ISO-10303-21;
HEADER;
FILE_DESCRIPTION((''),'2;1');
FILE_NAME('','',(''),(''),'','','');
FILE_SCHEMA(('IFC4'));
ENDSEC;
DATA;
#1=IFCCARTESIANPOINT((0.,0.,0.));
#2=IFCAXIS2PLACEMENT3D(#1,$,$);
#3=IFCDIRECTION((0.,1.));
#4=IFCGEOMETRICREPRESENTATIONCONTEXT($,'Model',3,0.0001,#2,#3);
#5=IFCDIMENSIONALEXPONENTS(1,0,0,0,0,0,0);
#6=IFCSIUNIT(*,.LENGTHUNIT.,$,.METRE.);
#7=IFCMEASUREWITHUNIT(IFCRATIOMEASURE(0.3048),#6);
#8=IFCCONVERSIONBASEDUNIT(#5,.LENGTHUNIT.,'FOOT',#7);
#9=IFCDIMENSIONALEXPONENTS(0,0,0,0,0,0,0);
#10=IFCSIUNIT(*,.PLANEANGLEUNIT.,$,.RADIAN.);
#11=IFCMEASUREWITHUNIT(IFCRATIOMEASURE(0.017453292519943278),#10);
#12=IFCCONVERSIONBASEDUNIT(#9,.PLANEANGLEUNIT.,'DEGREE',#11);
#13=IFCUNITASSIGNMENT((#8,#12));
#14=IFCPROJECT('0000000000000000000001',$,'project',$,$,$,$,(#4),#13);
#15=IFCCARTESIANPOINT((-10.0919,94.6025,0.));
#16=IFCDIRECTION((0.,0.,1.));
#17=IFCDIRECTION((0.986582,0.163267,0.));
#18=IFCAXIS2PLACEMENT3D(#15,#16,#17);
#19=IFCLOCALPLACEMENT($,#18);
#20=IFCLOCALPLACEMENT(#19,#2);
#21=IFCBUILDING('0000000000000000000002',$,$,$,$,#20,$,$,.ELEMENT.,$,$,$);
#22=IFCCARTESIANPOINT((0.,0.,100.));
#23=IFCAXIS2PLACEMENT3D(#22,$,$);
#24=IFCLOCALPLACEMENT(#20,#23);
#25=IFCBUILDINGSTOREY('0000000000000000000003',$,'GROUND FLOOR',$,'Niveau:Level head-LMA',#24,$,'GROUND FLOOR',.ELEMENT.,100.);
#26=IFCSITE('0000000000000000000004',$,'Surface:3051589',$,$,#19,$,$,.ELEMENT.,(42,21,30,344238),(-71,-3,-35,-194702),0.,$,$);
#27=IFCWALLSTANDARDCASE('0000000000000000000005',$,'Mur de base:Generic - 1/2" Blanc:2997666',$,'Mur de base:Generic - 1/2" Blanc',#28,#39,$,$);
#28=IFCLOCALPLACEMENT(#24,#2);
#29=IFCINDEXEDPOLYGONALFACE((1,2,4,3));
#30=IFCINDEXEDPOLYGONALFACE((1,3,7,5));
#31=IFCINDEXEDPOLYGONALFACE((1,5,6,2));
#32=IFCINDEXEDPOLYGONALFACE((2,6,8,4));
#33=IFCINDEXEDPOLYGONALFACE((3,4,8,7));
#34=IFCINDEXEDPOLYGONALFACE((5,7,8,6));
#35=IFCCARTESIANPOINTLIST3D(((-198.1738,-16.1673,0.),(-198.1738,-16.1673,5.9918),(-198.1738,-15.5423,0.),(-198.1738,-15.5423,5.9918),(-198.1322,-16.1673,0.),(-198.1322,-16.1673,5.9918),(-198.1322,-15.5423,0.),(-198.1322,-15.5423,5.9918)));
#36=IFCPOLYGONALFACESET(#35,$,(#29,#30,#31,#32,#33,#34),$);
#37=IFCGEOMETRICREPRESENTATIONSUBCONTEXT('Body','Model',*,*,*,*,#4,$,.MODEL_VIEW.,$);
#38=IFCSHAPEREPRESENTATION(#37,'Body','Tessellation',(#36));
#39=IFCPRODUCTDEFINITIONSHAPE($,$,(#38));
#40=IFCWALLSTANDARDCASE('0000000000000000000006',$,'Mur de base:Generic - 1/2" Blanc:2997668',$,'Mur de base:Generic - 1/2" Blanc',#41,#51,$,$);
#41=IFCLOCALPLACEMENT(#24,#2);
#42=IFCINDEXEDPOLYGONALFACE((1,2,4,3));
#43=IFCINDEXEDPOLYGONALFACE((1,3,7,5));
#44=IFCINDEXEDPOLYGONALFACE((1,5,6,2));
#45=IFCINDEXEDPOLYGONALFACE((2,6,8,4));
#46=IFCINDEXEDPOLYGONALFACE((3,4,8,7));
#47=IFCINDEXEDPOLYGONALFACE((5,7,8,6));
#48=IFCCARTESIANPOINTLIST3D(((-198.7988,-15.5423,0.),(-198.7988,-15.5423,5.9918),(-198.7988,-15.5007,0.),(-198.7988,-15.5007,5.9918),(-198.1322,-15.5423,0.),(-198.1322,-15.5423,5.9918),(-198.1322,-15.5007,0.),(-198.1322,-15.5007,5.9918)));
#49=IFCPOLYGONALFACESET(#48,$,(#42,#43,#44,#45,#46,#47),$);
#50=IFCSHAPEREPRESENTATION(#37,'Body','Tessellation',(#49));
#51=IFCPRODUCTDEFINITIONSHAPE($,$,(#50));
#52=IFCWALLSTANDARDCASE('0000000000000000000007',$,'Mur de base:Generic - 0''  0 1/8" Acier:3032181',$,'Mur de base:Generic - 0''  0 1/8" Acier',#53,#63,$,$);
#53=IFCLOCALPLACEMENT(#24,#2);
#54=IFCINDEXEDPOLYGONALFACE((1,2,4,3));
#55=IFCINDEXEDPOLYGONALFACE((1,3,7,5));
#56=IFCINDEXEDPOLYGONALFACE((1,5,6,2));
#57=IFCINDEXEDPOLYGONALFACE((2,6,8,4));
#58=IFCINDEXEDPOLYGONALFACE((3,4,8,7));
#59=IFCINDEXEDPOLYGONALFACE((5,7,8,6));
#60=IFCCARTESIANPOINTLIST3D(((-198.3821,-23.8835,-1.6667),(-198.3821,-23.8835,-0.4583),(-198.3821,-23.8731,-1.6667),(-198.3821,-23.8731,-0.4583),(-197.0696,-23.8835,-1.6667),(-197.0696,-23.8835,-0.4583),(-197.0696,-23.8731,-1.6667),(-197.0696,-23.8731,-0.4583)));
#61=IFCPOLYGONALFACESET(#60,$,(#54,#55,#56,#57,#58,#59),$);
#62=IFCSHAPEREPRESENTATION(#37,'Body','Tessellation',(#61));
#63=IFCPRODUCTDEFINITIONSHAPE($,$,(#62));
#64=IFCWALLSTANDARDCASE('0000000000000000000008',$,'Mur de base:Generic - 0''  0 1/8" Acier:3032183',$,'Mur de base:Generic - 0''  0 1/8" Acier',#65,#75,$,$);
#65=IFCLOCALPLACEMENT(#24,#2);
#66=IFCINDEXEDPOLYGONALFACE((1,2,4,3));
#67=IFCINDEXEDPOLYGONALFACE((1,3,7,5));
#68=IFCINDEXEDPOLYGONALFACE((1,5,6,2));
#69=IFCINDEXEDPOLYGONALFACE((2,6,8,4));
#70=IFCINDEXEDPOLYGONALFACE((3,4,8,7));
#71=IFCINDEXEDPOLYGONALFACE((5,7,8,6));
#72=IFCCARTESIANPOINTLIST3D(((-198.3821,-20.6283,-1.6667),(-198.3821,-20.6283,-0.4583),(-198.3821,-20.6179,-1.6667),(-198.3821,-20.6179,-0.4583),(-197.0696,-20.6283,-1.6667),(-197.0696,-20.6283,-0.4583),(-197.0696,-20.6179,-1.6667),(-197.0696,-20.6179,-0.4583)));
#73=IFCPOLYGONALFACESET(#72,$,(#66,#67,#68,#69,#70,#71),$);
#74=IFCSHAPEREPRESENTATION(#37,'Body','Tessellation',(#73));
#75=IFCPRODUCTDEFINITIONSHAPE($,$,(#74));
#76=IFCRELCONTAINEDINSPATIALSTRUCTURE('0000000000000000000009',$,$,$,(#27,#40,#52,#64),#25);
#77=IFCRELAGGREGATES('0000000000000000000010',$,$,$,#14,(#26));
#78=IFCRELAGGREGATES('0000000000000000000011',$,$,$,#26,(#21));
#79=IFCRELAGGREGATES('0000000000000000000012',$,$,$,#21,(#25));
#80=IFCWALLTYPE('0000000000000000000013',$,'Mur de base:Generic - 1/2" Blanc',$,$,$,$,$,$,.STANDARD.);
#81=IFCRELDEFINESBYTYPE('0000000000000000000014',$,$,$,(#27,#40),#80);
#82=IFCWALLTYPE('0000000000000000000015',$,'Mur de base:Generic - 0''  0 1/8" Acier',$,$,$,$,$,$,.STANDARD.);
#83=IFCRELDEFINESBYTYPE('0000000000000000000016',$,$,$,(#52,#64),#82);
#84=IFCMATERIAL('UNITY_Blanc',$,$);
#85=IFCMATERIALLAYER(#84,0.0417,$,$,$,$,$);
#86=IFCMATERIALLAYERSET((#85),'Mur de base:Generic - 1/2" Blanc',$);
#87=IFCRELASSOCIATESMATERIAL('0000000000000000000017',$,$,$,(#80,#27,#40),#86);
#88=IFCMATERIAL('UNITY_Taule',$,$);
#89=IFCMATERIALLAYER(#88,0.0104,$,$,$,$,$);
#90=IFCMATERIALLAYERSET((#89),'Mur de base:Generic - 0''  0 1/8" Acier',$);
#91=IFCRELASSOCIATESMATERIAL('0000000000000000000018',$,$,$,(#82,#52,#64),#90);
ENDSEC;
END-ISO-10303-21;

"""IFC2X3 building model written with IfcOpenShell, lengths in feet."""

from ifc_helpers import new_model, entity, si_unit, converted_unit, direction, frame, frame_2d, origin, place, context, subcontext, project, spatial, polyline, rectangle, extrude, clip, bounded_halfspace, material, layer, layer_set, layer_usage, type_object, element, save


model = new_model("IFC2X3")

# Units and contexts
model_context = context("Model", 3, precision=0.0001, world=origin(), true_north=direction((0.0, 1.0)))
body_context = subcontext(model_context, "Body", "Model", "MODEL_VIEW")
ifc_project = project(units=[converted_unit("LENGTHUNIT", "FOOT", entity("IfcRatioMeasure", 0.3048), si_unit("LENGTHUNIT", "METRE"), dimensions=[1, 0, 0, 0, 0, 0, 0]), converted_unit("PLANEANGLEUNIT", "DEGREE", entity("IfcRatioMeasure", 0.017453292519943278), si_unit("PLANEANGLEUNIT", "RADIAN"), dimensions=[0, 0, 0, 0, 0, 0, 0])], contexts=[model_context])

# Site, building, storey
site_placement = place(None, frame((-10.0919, 94.6025, 0.0), z_axis=(0.0, 0.0, 1.0), x_axis=(0.986582, 0.163267, 0.0)))
site = spatial("IfcSite", under=ifc_project, at=site_placement, Name="Surface:3051589", CompositionType="ELEMENT", RefLatitude=(42, 21, 30, 344238), RefLongitude=(-71, -3, -35, -194702), RefElevation=0.0)
building_placement = place(site_placement, origin())
building = spatial("IfcBuilding", under=site, at=building_placement, CompositionType="ELEMENT")
storey_placement = place(building_placement, frame((0.0, 0.0, 100.0)))
storey = spatial("IfcBuildingStorey", under=building, at=storey_placement, Name="GROUND FLOOR", ObjectType="Niveau:Level head-LMA", LongName="GROUND FLOOR", CompositionType="ELEMENT", Elevation=100.0)

# Walls
ifc_material_1 = material(Name="UNITY_Blanc")
ifc_layer_1 = layer(ifc_material_1, 0.0417)
ifc_layer_set_1 = layer_set([ifc_layer_1], Name="Mur de base:Generic - 1/2\" Blanc")
ifc_layer_usage_1 = layer_usage(ifc_layer_set_1, "AXIS2", "POSITIVE", -0.0208)
wall_type_1 = type_object("IfcWallType", Name="Mur de base:Generic - 1/2\" Blanc", PredefinedType="STANDARD", material=ifc_layer_set_1)
wall_1_placement = place(storey_placement, frame((-198.153, -16.1673, 0.0), z_axis=(0.0, 0.0, 1.0), x_axis=(0.0, 1.0, 0.0)))
element("IfcWallStandardCase", 1, at=wall_1_placement, inside=storey, type_object=wall_type_1, material=ifc_layer_usage_1, Name="Mur de base:Generic - 1/2\" Blanc:2997666", ObjectType="Mur de base:Generic - 1/2\" Blanc", context=body_context, shape_type="Clipping", body=[
    clip(extrude(rectangle(XDim=0.625, YDim=0.0417, at=frame_2d((0.3125, 0.0), x_axis=(-1.0, 0.0))), origin(), (0.0, 0.0, 1.0), 5.9918), bounded_halfspace(frame((0.0, -0.0208, 9.9189), z_axis=(0.0, -0.721387, 0.692532), x_axis=(1.0, 0.0, 0.0)), False, frame((0.0, -0.0208, 9.9189)), polyline([(0.0, 0.0), (0.625, 0.0), (0.625, 0.0417), (0.0, 0.0417), (0.0, 0.0)]))),
])
ifc_layer_usage_2 = layer_usage(ifc_layer_set_1, "AXIS2", "POSITIVE", -0.0208)
wall_2_placement = place(storey_placement, frame((-198.1322, -15.5215, 0.0), z_axis=(0.0, 0.0, 1.0), x_axis=(-1.0, 0.0, 0.0)))
element("IfcWallStandardCase", 2, at=wall_2_placement, inside=storey, type_object=wall_type_1, material=ifc_layer_usage_2, Name="Mur de base:Generic - 1/2\" Blanc:2997668", ObjectType="Mur de base:Generic - 1/2\" Blanc", context=body_context, shape_type="Clipping", body=[
    clip(extrude(rectangle(XDim=0.6667, YDim=0.0417, at=frame_2d((0.3333, 0.0), x_axis=(-1.0, 0.0))), origin(), (0.0, 0.0, 1.0), 5.9918), bounded_halfspace(frame((0.0, -0.0208, 9.9189), z_axis=(-0.721387, 0.0, 0.692532), x_axis=(0.0, -1.0, 0.0)), False, frame((0.0, -0.0208, 9.9189)), polyline([(0.0, 0.0), (0.6667, 0.0), (0.6667, 0.0417), (0.0417, 0.0417), (0.0, 0.0417), (0.0, 0.0)]))),
])
ifc_material_2 = material(Name="UNITY_Taule")
ifc_layer_2 = layer(ifc_material_2, 0.0104)
ifc_layer_set_2 = layer_set([ifc_layer_2], Name="Mur de base:Generic - 0'  0 1/8\" Acier")
wall_type_2 = type_object("IfcWallType", Name="Mur de base:Generic - 0'  0 1/8\" Acier", PredefinedType="STANDARD", material=ifc_layer_set_2)
ifc_layer_usage_3 = layer_usage(ifc_layer_set_2, "AXIS2", "NEGATIVE", 0.0052)
wall_3_placement = place(storey_placement, frame((-198.3821, -23.8783, -1.6667)))
element("IfcWallStandardCase", 3, at=wall_3_placement, inside=storey, type_object=wall_type_2, material=ifc_layer_usage_3, Name="Mur de base:Generic - 0'  0 1/8\" Acier:3032181", ObjectType="Mur de base:Generic - 0'  0 1/8\" Acier", context=body_context, shape_type="SweptSolid", body=[
    extrude(rectangle(XDim=1.3126, YDim=0.0104, at=frame_2d((0.6563, 0.0), x_axis=(-1.0, 0.0))), origin(), (0.0, 0.0, 1.0), 1.2083),
])
ifc_layer_usage_4 = layer_usage(ifc_layer_set_2, "AXIS2", "POSITIVE", -0.0052)
wall_4_placement = place(storey_placement, frame((-198.3821, -20.6231, -1.6667)))
element("IfcWallStandardCase", 4, at=wall_4_placement, inside=storey, type_object=wall_type_2, material=ifc_layer_usage_4, Name="Mur de base:Generic - 0'  0 1/8\" Acier:3032183", ObjectType="Mur de base:Generic - 0'  0 1/8\" Acier", context=body_context, shape_type="SweptSolid", body=[
    extrude(rectangle(XDim=1.3126, YDim=0.0104, at=frame_2d((0.6563, 0.0), x_axis=(-1.0, 0.0))), origin(), (0.0, 0.0, 1.0), 1.2083),
])

save(model, "model.ifc")
